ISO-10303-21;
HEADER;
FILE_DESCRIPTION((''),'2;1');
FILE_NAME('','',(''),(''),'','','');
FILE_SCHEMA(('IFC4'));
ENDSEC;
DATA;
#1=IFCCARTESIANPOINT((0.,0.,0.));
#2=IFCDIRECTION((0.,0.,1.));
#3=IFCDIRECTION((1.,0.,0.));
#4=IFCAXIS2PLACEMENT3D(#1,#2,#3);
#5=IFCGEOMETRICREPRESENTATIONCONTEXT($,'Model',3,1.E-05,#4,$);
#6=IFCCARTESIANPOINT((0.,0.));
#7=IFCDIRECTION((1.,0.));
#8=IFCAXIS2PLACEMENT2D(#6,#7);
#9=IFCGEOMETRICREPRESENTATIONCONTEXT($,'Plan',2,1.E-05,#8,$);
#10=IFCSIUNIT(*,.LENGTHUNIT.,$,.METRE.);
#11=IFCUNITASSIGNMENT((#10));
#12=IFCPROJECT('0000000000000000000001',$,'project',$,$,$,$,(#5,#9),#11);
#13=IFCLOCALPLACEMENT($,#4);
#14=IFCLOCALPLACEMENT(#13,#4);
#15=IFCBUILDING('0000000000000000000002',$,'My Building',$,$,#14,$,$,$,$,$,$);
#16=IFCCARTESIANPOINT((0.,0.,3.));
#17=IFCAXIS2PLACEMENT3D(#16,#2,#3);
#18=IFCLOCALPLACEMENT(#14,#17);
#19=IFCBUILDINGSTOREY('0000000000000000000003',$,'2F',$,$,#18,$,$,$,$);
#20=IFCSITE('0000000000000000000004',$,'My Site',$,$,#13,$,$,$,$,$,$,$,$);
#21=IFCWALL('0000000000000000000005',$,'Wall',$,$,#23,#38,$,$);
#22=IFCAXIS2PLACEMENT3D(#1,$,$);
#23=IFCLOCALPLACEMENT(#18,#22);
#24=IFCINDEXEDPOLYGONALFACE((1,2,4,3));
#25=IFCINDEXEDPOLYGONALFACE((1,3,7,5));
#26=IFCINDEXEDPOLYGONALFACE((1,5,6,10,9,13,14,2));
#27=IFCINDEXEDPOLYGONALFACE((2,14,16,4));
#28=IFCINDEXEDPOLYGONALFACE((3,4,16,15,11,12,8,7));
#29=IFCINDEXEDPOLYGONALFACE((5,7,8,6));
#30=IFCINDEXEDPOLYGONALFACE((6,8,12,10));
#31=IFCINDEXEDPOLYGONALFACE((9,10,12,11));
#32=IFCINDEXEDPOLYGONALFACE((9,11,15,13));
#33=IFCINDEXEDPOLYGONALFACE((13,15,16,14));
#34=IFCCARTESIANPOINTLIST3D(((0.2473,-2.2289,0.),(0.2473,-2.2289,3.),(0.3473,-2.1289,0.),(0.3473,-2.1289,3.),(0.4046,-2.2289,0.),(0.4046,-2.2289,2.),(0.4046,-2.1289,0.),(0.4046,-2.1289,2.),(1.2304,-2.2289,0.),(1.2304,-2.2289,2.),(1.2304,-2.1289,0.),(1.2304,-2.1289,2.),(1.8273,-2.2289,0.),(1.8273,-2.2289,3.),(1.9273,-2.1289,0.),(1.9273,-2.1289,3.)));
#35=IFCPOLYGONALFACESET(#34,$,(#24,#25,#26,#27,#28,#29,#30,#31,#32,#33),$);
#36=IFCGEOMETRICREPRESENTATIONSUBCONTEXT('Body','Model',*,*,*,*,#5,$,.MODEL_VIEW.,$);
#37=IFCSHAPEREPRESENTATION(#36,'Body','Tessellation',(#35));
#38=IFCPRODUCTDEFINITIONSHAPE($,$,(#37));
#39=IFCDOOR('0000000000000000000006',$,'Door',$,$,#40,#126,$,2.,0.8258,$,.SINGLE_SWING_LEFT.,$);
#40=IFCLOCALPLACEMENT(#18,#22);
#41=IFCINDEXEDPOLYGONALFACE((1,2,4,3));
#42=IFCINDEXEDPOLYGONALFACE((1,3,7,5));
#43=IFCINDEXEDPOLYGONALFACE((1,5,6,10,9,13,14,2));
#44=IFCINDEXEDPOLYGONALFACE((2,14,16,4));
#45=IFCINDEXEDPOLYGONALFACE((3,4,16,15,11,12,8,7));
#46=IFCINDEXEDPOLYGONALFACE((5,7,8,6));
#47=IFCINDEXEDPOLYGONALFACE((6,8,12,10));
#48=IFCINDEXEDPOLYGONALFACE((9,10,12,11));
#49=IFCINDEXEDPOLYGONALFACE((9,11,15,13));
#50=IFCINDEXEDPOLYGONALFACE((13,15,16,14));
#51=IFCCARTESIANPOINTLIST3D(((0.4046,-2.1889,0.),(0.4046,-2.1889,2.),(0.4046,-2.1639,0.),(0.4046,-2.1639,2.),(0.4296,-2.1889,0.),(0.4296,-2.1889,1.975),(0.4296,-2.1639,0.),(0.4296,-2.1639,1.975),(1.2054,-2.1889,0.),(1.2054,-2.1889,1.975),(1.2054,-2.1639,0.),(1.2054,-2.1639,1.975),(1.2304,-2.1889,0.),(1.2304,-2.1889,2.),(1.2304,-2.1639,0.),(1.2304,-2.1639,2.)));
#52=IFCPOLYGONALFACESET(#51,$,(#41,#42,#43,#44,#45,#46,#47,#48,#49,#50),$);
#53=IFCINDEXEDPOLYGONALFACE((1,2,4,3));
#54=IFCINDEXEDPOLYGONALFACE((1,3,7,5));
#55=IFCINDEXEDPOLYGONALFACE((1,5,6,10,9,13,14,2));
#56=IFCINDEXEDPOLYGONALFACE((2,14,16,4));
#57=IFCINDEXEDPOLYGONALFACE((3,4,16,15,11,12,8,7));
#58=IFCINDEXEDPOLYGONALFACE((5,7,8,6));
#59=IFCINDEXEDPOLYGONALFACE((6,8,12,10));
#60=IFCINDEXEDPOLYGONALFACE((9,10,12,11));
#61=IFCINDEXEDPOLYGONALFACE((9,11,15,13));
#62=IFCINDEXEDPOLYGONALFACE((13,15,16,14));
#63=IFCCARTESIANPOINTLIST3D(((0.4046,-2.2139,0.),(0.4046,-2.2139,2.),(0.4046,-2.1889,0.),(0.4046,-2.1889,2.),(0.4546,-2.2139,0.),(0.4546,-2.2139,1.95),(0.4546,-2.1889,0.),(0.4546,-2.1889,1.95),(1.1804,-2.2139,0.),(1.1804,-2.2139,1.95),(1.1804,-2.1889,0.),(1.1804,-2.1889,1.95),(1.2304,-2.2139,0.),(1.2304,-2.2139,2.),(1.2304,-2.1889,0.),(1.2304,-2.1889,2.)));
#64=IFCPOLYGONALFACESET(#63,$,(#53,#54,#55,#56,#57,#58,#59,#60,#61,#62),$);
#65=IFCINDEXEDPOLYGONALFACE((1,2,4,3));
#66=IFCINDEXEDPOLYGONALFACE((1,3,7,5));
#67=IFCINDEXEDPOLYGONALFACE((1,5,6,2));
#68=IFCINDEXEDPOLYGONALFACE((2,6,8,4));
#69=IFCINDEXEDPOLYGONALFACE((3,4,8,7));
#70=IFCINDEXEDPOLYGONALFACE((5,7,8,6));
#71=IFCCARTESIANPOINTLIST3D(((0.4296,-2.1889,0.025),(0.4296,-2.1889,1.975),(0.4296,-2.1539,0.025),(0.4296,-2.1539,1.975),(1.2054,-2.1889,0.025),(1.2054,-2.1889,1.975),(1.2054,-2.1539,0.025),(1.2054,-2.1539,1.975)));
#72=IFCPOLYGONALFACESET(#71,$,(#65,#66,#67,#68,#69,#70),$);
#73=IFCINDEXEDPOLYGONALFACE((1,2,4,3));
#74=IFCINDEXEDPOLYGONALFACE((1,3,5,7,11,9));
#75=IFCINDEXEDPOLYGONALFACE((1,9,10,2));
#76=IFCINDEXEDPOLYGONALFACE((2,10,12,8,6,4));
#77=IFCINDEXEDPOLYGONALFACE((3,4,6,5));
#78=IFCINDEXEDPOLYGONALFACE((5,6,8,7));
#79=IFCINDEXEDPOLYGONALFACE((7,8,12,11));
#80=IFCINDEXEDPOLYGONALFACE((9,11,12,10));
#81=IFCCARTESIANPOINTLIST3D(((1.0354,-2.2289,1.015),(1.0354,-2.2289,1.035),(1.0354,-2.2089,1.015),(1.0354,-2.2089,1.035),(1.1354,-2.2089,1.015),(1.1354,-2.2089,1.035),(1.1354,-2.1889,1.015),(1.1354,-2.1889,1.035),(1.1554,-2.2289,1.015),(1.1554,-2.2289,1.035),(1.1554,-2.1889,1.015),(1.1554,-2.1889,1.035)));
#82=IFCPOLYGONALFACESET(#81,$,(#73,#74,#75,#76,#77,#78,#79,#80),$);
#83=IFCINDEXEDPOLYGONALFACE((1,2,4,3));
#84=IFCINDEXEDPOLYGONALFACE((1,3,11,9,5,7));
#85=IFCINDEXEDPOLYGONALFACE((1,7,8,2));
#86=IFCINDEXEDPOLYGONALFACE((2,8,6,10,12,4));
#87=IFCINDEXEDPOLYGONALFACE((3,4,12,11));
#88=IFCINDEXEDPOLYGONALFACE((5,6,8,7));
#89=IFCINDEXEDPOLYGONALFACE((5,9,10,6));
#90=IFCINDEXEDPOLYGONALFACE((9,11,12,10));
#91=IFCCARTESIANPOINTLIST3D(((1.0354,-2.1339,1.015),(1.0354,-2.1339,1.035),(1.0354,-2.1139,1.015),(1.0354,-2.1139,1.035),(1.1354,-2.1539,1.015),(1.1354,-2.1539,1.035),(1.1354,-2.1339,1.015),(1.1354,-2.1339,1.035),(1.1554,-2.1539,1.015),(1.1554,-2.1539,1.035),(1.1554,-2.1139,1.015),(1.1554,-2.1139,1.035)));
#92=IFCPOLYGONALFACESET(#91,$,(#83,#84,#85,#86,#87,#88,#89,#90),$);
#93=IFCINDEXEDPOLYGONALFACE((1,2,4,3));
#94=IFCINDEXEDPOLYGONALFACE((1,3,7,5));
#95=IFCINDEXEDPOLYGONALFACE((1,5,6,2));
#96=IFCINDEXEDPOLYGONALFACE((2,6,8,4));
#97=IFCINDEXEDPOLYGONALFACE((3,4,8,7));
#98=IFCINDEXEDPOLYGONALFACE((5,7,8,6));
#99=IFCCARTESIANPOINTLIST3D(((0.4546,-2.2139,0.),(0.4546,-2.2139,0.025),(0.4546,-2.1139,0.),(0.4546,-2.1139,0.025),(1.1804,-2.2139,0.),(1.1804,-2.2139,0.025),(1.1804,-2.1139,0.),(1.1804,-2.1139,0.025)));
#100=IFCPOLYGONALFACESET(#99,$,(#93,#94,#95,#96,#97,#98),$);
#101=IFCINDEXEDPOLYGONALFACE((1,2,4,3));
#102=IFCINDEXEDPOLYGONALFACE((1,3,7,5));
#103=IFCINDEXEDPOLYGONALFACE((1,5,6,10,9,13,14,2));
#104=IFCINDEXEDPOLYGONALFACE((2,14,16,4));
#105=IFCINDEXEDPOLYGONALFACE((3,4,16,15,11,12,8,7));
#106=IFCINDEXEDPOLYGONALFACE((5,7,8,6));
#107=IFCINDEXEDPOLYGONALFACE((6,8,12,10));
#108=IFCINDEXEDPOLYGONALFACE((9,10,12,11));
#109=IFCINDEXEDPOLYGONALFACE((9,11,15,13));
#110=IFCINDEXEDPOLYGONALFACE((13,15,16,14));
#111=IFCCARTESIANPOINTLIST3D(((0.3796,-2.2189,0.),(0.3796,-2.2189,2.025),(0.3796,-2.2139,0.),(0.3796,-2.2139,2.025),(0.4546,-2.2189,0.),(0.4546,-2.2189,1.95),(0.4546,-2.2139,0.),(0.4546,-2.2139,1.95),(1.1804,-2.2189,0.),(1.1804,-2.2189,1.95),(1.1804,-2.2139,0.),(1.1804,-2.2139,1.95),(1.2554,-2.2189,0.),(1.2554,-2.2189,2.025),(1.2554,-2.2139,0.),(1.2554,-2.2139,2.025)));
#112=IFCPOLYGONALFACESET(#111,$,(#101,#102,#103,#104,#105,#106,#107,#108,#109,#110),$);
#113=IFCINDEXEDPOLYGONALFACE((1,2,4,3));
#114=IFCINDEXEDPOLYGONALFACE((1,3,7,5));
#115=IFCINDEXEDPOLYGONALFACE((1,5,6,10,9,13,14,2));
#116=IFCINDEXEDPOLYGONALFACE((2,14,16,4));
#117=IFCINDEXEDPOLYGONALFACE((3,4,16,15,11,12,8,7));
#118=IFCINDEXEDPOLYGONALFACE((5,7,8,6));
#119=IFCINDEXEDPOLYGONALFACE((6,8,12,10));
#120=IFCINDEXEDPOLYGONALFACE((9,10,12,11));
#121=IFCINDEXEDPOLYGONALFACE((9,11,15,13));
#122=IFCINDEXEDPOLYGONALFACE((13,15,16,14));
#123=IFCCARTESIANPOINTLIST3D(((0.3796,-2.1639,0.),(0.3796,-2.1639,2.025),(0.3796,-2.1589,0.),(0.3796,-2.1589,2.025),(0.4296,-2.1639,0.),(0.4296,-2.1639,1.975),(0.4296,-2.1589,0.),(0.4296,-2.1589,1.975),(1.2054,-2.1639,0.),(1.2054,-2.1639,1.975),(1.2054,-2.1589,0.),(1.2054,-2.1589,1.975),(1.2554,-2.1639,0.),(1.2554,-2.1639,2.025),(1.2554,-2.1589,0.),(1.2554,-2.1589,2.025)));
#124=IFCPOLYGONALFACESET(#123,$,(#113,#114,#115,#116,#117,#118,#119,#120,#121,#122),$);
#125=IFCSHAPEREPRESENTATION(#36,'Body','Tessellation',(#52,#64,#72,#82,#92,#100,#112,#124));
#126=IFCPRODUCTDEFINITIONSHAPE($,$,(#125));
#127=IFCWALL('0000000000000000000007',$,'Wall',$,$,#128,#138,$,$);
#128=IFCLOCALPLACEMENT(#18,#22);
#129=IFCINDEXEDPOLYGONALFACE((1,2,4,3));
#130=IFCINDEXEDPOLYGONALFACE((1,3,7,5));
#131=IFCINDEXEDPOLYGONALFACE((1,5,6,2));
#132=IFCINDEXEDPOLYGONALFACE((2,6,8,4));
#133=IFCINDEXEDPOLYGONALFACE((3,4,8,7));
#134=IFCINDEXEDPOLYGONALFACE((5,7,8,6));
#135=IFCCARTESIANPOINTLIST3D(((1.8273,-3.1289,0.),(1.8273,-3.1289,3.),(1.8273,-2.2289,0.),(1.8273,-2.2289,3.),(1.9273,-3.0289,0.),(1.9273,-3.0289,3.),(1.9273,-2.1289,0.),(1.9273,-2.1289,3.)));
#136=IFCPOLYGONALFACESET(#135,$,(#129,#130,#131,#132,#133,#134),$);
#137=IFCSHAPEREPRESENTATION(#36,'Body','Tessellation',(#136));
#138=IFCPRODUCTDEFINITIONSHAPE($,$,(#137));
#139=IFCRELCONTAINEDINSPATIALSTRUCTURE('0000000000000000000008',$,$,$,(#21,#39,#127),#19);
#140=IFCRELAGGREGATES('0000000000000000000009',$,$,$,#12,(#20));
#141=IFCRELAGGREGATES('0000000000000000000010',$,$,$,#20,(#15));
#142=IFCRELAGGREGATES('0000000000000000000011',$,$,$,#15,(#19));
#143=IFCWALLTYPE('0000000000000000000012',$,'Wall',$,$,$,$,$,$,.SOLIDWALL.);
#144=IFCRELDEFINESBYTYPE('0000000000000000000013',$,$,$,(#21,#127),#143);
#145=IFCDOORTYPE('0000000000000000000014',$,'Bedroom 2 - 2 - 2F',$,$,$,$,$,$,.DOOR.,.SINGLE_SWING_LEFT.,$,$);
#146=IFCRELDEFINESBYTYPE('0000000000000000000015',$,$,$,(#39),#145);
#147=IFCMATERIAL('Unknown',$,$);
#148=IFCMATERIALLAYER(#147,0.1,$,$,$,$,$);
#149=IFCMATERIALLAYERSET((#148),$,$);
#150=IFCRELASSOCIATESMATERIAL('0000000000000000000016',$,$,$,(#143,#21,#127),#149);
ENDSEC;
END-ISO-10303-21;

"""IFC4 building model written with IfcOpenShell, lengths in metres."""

from ifc_helpers import new_model, entity, si_unit, frame, origin_with_axes, origin_2d_with_axis, place, context, subcontext, project, spatial, line, indexed_curve, outline, extrude, shape, source, transform, mapped, material, layer, layer_set, layer_usage, type_object, type_shapes, element, fill, save


model = new_model("IFC4")

# Units and contexts
model_context = context("Model", 3, precision=1e-05, world=origin_with_axes())
plan_context = context("Plan", 2, precision=1e-05, world=origin_2d_with_axis())
body_context_1 = subcontext(model_context, "Body", "Model", "MODEL_VIEW")
body_context_2 = subcontext(plan_context, "Body", "Plan", "PLAN_VIEW")
ifc_project = project(units=[si_unit("LENGTHUNIT", "METRE")], contexts=[model_context, plan_context])

# Site, building, storey
site_placement = place(None, origin_with_axes())
site = spatial("IfcSite", under=ifc_project, at=site_placement, Name="My Site")
building_placement = place(site_placement, origin_with_axes())
building = spatial("IfcBuilding", under=site, at=building_placement, Name="My Building")
storey_placement = place(building_placement, frame((0.0, 0.0, 3.0), z_axis=(0.0, 0.0, 1.0), x_axis=(1.0, 0.0, 0.0)))
storey = spatial("IfcBuildingStorey", under=building, at=storey_placement, Name="2F")

# Shared definitions
ifc_material_1 = material(Name="Unknown")
ifc_layer_1 = layer(ifc_material_1, 0.1)
ifc_layer_set_1 = layer_set([ifc_layer_1])
wall_type_1 = type_object("IfcWallType", Name="Wall", PredefinedType="SOLIDWALL", material=ifc_layer_set_1)

# Wall, opening, door
ifc_layer_usage_1 = layer_usage(ifc_layer_set_1, "AXIS2", "POSITIVE", 0.0)
wall_1_placement = place(storey_placement, frame((0.2473, -2.2289, 0.0), z_axis=(0.0, 0.0, 1.0), x_axis=(1.0, 0.0, 0.0)))
wall_1 = element("IfcWall", 1, at=wall_1_placement, inside=storey, type_object=wall_type_1, material=ifc_layer_usage_1, Name="Wall", context=body_context_1, shape_type="SweptSolid", body=[
    extrude(outline(indexed_curve([(0.0, 0.0), (0.1, 0.1), (1.68, 0.1), (1.58, 0.0)], segments=[line(1, 2, 3, 4, 1)])), origin_with_axes(), (0.0, 0.0, 1.0), 3.0),
])
shared_shape_1 = source(origin_with_axes(), body_context_1, "Body", "SweptSolid", [
    extrude(outline(indexed_curve([(0.0, 0.0), (0.8258, 0.0), (0.8258, 2.0), (0.0, 2.0)], segments=[line(1, 2, 3, 4, 1)])), frame((0.0, -0.6, 0.0), z_axis=(0.0, -1.0, 0.0), x_axis=(1.0, 0.0, 0.0)), (0.0, 0.0, -1.0), 1.2),
])
opening_1_placement = place(wall_1_placement, frame((0.1573, 0.015, 0.0), z_axis=(0.0, 0.0, 1.0), x_axis=(1.0, 0.0, 0.0)))
opening_1 = element("IfcOpeningElement", 2, at=opening_1_placement, cuts=wall_1, PredefinedType="OPENING", context=body_context_1, shape_type="MappedRepresentation", body=[
    mapped(shared_shape_1, transform((0.0, 0.0, 0.0), x_axis=(1.0, 0.0, 0.0), y_axis=(0.0, 1.0, 0.0), z_axis=(0.0, 0.0, 1.0), scale=1.0)),
])
door_type_1 = type_object("IfcDoorType", Name="Bedroom 2 - 2 - 2F", OperationType="SINGLE_SWING_LEFT", PredefinedType="DOOR")
shared_shape_2 = source(origin_with_axes(), body_context_1, "Body", "SweptSolid", [
    extrude(outline(indexed_curve([(0.0, 0.0), (0.0, 2.0), (0.8258, 2.0), (0.8258, 0.0), (0.8008, 0.0), (0.8008, 1.975), (0.025, 1.975), (0.025, 0.0)], segments=[line(1, 2, 3, 4, 5, 6, 7, 8, 1)])), frame((0.0, 0.025, 0.0), z_axis=(0.0, -1.0, 0.0), x_axis=(1.0, 0.0, 0.0)), (0.0, 0.0, -1.0), 0.025),
    extrude(outline(indexed_curve([(0.0, 0.0), (0.0, 2.0), (0.8258, 2.0), (0.8258, 0.0), (0.7758, 0.0), (0.7758, 1.95), (0.05, 1.95), (0.05, 0.0)], segments=[line(1, 2, 3, 4, 5, 6, 7, 8, 1)])), frame((0.0, 0.0, 0.0), z_axis=(0.0, -1.0, 0.0), x_axis=(1.0, 0.0, 0.0)), (0.0, 0.0, -1.0), 0.025),
    extrude(outline(indexed_curve([(0.0, 0.0), (0.7758, 0.0), (0.7758, 0.035), (0.0, 0.035)], segments=[line(1, 2, 3, 4, 1)])), frame((0.025, 0.025, 0.025), z_axis=(0.0, 0.0, 1.0), x_axis=(1.0, 0.0, 0.0)), (0.0, 0.0, 1.0), 1.95),
    extrude(outline(indexed_curve([(0.0, 0.0), (0.0, -0.04), (-0.12, -0.04), (-0.12, -0.02), (-0.02, -0.02), (-0.02, 0.0)], segments=[line(1, 2, 3, 4, 5, 6, 1)])), frame((0.7508, 0.025, 1.015), z_axis=(0.0, 0.0, 1.0), x_axis=(1.0, 0.0, 0.0)), (0.0, 0.0, 1.0), 0.02),
    extrude(outline(indexed_curve([(0.0, 0.0), (0.0, 0.04), (-0.12, 0.04), (-0.12, 0.02), (-0.02, 0.02), (-0.02, 0.0)], segments=[line(1, 2, 3, 4, 5, 6, 1)])), frame((0.7508, 0.06, 1.015), z_axis=(0.0, 0.0, 1.0), x_axis=(1.0, 0.0, 0.0)), (0.0, 0.0, 1.0), 0.02),
    extrude(outline(indexed_curve([(0.0, 0.0), (0.7258, 0.0), (0.7258, 0.1), (0.0, 0.1)], segments=[line(1, 2, 3, 4, 1)])), frame((0.05, 0.0, 0.0), z_axis=(0.0, 0.0, 1.0), x_axis=(1.0, 0.0, 0.0)), (0.0, 0.0, 1.0), 0.025),
    extrude(outline(indexed_curve([(0.0, 0.0), (0.0, 2.025), (0.8758, 2.025), (0.8758, 0.0), (0.8008, 0.0), (0.8008, 1.95), (0.075, 1.95), (0.075, 0.0)], segments=[line(1, 2, 3, 4, 5, 6, 7, 8, 1)])), frame((-0.025, -0.005, 0.0), z_axis=(0.0, -1.0, 0.0), x_axis=(1.0, 0.0, 0.0)), (0.0, 0.0, -1.0), 0.005),
    extrude(outline(indexed_curve([(0.0, 0.0), (0.0, 2.025), (0.8758, 2.025), (0.8758, 0.0), (0.8258, 0.0), (0.8258, 1.975), (0.05, 1.975), (0.05, 0.0)], segments=[line(1, 2, 3, 4, 5, 6, 7, 8, 1)])), frame((-0.025, 0.05, 0.0), z_axis=(0.0, -1.0, 0.0), x_axis=(1.0, 0.0, 0.0)), (0.0, 0.0, -1.0), 0.005),
])
shared_shape_3 = source(origin_with_axes(), body_context_2, "Body", "Curve2D", [
    entity("IfcIndexedPolyCurve", entity("IfcCartesianPointList2D", [[0.0, 0.0], [0.0, 0.05], [0.025, 0.05], [0.025, 0.025], [0.05, 0.025], [0.05, 0.0]]), [entity("IfcLineIndex", [1, 2, 3, 4, 5, 6, 1])]),
    entity("IfcIndexedPolyCurve", entity("IfcCartesianPointList2D", [[0.8258, 0.0], [0.8258, 0.05], [0.8008, 0.05], [0.8008, 0.025], [0.7758, 0.025], [0.7758, 0.0]]), [entity("IfcLineIndex", [1, 2, 3, 4, 5, 6, 1])]),
    entity("IfcTrimmedCurve", entity("IfcEllipse", entity("IfcAxis2Placement2D", entity("IfcCartesianPoint", [0.06, 0.05]), entity("IfcDirection", [1.0, 0.0])), 0.7408, 0.7758), [entity("IfcCartesianPoint", [0.8008, 0.05])], [entity("IfcCartesianPoint", [0.06, 0.8258])], True, "CARTESIAN"),
    entity("IfcIndexedPolyCurve", entity("IfcCartesianPointList2D", [[0.025, 0.05], [0.06, 0.05], [0.06, 0.8258], [0.025, 0.8258]]), [entity("IfcLineIndex", [1, 2, 3, 4, 1])]),
])
type_shapes(door_type_1, [shared_shape_2, shared_shape_3])
door_1_placement = place(opening_1_placement, frame((0.0, 0.0, 0.0), z_axis=(0.0, 0.0, 1.0), x_axis=(1.0, 0.0, 0.0)))
door_1 = element("IfcDoor", 3, at=door_1_placement, inside=storey, type_object=door_type_1, Name="Door", OperationType="SINGLE_SWING_LEFT", OverallHeight=2.0, OverallWidth=0.8258, shapes=[
    shape(body_context_1, "Body", "MappedRepresentation", [mapped(shared_shape_2, transform((0.0, 0.0, 0.0), x_axis=(1.0, 0.0, 0.0), y_axis=(0.0, 1.0, 0.0), z_axis=(0.0, 0.0, 1.0), scale=1.0))]),
    shape(body_context_2, "Body", "MappedRepresentation", [mapped(shared_shape_3, transform((0.0, 0.0, 0.0), x_axis=(1.0, 0.0, 0.0), y_axis=(0.0, 1.0, 0.0), z_axis=(0.0, 0.0, 1.0), scale=1.0))]),
])
fill(opening_1, door_1)

# Wall
ifc_layer_usage_2 = layer_usage(ifc_layer_set_1, "AXIS2", "POSITIVE", 0.0)
wall_2_placement = place(storey_placement, frame((1.8273, -2.2289, 0.0), z_axis=(0.0, 0.0, 1.0), x_axis=(0.0, -1.0, 0.0)))
element("IfcWall", 4, at=wall_2_placement, inside=storey, type_object=wall_type_1, material=ifc_layer_usage_2, Name="Wall", context=body_context_1, shape_type="SweptSolid", body=[
    extrude(outline(indexed_curve([(0.0, 0.0), (-0.1, 0.1), (0.8, 0.1), (0.9, 0.0)], segments=[line(1, 2, 3, 4, 1)])), origin_with_axes(), (0.0, 0.0, 1.0), 3.0),
])

save(model, "model.ifc")
